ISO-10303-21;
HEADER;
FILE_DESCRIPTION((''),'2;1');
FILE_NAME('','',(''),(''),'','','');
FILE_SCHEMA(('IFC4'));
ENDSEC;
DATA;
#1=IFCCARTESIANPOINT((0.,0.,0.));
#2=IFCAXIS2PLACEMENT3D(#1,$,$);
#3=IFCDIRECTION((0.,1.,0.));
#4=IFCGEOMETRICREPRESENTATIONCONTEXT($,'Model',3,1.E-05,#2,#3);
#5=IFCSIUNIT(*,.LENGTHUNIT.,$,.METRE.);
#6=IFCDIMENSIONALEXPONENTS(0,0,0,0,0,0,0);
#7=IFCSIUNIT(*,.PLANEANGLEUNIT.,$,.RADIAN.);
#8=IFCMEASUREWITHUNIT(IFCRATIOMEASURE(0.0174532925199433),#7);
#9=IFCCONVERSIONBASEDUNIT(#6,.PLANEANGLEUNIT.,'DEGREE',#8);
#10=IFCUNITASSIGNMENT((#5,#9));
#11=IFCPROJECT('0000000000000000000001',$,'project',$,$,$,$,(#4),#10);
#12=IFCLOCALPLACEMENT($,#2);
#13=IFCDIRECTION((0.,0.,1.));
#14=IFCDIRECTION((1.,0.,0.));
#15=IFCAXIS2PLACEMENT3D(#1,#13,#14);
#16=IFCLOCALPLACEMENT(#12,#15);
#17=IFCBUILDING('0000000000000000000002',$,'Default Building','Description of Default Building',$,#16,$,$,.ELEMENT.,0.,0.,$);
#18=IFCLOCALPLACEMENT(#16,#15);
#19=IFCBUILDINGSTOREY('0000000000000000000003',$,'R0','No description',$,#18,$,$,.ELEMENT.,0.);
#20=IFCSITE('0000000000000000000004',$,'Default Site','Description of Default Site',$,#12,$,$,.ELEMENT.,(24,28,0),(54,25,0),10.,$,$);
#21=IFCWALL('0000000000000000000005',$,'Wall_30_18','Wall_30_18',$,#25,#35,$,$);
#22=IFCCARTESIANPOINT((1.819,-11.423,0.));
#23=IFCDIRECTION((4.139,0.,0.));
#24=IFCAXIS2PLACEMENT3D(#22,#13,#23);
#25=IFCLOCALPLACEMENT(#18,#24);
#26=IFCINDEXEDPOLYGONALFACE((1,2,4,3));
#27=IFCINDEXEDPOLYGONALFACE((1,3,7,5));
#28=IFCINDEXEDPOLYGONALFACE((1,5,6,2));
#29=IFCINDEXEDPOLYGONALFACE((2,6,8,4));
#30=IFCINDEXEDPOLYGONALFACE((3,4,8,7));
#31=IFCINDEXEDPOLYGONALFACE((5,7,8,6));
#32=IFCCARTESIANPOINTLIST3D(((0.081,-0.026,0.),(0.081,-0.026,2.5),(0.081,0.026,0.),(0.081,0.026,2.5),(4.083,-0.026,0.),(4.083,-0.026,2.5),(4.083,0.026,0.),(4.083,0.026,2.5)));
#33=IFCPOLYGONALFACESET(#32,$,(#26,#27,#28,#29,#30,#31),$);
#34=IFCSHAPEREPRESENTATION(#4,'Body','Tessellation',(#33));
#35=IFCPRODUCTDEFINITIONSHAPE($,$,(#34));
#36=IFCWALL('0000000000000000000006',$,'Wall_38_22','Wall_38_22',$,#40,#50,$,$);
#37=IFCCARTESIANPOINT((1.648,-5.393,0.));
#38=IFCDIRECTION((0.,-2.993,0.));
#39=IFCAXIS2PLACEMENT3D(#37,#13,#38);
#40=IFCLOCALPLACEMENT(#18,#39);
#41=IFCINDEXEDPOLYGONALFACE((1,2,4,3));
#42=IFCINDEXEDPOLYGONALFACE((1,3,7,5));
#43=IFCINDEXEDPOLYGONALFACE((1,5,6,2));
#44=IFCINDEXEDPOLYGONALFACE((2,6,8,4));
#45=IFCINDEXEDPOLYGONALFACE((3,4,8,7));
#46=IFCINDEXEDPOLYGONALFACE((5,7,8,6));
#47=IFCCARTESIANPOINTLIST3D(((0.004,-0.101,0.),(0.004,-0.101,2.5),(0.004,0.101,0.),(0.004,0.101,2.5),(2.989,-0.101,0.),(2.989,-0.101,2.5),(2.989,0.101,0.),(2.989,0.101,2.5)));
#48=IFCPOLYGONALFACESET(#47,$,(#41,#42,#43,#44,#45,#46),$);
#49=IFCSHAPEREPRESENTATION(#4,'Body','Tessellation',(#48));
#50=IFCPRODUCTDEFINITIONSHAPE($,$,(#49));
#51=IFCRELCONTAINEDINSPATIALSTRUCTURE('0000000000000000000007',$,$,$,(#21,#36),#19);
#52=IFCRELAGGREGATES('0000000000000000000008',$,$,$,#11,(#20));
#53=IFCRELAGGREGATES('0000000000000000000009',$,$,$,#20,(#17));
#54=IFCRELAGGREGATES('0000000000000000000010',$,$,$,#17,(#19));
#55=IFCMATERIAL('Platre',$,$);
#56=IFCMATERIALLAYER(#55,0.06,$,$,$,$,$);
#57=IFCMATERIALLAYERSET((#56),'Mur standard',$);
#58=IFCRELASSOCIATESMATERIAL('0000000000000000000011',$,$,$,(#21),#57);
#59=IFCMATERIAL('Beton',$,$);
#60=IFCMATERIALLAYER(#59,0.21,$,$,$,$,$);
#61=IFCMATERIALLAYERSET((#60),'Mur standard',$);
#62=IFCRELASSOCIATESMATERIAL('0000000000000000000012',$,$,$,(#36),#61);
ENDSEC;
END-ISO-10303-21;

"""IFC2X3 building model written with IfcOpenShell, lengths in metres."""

from ifc_helpers import new_model, entity, si_unit, converted_unit, direction, frame, origin, origin_with_axes, place, context, project, spatial, polyline, outline, extrude, material, layer, layer_set, layer_usage, element, save


model = new_model("IFC2X3")

# Units and contexts
model_context = context("Model", 3, precision=1e-05, world=origin(), true_north=direction((0.0, 1.0, 0.0)))
ifc_project = project(units=[si_unit("LENGTHUNIT", "METRE"), converted_unit("PLANEANGLEUNIT", "DEGREE", entity("IfcRatioMeasure", 0.0174532925199433), si_unit("PLANEANGLEUNIT", "RADIAN"), dimensions=[0, 0, 0, 0, 0, 0, 0])], contexts=[model_context])

# Site, building, storey
site_placement = place(None, origin())
site = spatial("IfcSite", under=ifc_project, at=site_placement, Name="Default Site", Description="Description of Default Site", CompositionType="ELEMENT", RefLatitude=(24, 28, 0), RefLongitude=(54, 25, 0), RefElevation=10.0)
building_placement = place(site_placement, origin_with_axes())
building = spatial("IfcBuilding", under=site, at=building_placement, Name="Default Building", Description="Description of Default Building", CompositionType="ELEMENT", ElevationOfRefHeight=0.0, ElevationOfTerrain=0.0)
storey_placement = place(building_placement, origin_with_axes())
storey = spatial("IfcBuildingStorey", under=building, at=storey_placement, Name="R0", Description="No description", CompositionType="ELEMENT", Elevation=0.0)

# Shared definitions
ifc_material_1 = material(Name="Platre")
ifc_layer_1 = layer(ifc_material_1, 0.06)
ifc_layer_set_1 = layer_set([ifc_layer_1], Name="Mur standard")
ifc_layer_usage_1 = layer_usage(ifc_layer_set_1, "AXIS2", "NEGATIVE", 0.06)

# Wall
wall_1_placement = place(storey_placement, frame((1.819, -11.423, 0.0), z_axis=(0.0, 0.0, 1.0), x_axis=(4.139, 0.0, 0.0)))
element("IfcWall", 1, at=wall_1_placement, inside=storey, material=ifc_layer_usage_1, Name="Wall_30_18", Description="Wall_30_18", context=model_context, shape_type="SweptSolid", body=[
    extrude(outline(polyline([(0.081, 0.026), (0.081, -0.026), (4.083, -0.026), (4.083, 0.026), (0.081, 0.026)])), origin(), (0.0, 0.0, 1.0), 2.5),
])

# Shared definitions
ifc_material_2 = material(Name="Beton")
ifc_layer_2 = layer(ifc_material_2, 0.21)
ifc_layer_set_2 = layer_set([ifc_layer_2], Name="Mur standard")
ifc_layer_usage_2 = layer_usage(ifc_layer_set_2, "AXIS2", "NEGATIVE", 0.21)

# Wall
wall_2_placement = place(storey_placement, frame((1.648, -5.393, 0.0), z_axis=(0.0, 0.0, 1.0), x_axis=(0.0, -2.993, 0.0)))
element("IfcWall", 2, at=wall_2_placement, inside=storey, material=ifc_layer_usage_2, Name="Wall_38_22", Description="Wall_38_22", context=model_context, shape_type="SweptSolid", body=[
    extrude(outline(polyline([(0.004, -0.101), (2.989, -0.101), (2.989, 0.101), (0.004, 0.101), (0.004, -0.101)])), origin(), (0.0, 0.0, 1.0), 2.5),
])

save(model, "model.ifc")
